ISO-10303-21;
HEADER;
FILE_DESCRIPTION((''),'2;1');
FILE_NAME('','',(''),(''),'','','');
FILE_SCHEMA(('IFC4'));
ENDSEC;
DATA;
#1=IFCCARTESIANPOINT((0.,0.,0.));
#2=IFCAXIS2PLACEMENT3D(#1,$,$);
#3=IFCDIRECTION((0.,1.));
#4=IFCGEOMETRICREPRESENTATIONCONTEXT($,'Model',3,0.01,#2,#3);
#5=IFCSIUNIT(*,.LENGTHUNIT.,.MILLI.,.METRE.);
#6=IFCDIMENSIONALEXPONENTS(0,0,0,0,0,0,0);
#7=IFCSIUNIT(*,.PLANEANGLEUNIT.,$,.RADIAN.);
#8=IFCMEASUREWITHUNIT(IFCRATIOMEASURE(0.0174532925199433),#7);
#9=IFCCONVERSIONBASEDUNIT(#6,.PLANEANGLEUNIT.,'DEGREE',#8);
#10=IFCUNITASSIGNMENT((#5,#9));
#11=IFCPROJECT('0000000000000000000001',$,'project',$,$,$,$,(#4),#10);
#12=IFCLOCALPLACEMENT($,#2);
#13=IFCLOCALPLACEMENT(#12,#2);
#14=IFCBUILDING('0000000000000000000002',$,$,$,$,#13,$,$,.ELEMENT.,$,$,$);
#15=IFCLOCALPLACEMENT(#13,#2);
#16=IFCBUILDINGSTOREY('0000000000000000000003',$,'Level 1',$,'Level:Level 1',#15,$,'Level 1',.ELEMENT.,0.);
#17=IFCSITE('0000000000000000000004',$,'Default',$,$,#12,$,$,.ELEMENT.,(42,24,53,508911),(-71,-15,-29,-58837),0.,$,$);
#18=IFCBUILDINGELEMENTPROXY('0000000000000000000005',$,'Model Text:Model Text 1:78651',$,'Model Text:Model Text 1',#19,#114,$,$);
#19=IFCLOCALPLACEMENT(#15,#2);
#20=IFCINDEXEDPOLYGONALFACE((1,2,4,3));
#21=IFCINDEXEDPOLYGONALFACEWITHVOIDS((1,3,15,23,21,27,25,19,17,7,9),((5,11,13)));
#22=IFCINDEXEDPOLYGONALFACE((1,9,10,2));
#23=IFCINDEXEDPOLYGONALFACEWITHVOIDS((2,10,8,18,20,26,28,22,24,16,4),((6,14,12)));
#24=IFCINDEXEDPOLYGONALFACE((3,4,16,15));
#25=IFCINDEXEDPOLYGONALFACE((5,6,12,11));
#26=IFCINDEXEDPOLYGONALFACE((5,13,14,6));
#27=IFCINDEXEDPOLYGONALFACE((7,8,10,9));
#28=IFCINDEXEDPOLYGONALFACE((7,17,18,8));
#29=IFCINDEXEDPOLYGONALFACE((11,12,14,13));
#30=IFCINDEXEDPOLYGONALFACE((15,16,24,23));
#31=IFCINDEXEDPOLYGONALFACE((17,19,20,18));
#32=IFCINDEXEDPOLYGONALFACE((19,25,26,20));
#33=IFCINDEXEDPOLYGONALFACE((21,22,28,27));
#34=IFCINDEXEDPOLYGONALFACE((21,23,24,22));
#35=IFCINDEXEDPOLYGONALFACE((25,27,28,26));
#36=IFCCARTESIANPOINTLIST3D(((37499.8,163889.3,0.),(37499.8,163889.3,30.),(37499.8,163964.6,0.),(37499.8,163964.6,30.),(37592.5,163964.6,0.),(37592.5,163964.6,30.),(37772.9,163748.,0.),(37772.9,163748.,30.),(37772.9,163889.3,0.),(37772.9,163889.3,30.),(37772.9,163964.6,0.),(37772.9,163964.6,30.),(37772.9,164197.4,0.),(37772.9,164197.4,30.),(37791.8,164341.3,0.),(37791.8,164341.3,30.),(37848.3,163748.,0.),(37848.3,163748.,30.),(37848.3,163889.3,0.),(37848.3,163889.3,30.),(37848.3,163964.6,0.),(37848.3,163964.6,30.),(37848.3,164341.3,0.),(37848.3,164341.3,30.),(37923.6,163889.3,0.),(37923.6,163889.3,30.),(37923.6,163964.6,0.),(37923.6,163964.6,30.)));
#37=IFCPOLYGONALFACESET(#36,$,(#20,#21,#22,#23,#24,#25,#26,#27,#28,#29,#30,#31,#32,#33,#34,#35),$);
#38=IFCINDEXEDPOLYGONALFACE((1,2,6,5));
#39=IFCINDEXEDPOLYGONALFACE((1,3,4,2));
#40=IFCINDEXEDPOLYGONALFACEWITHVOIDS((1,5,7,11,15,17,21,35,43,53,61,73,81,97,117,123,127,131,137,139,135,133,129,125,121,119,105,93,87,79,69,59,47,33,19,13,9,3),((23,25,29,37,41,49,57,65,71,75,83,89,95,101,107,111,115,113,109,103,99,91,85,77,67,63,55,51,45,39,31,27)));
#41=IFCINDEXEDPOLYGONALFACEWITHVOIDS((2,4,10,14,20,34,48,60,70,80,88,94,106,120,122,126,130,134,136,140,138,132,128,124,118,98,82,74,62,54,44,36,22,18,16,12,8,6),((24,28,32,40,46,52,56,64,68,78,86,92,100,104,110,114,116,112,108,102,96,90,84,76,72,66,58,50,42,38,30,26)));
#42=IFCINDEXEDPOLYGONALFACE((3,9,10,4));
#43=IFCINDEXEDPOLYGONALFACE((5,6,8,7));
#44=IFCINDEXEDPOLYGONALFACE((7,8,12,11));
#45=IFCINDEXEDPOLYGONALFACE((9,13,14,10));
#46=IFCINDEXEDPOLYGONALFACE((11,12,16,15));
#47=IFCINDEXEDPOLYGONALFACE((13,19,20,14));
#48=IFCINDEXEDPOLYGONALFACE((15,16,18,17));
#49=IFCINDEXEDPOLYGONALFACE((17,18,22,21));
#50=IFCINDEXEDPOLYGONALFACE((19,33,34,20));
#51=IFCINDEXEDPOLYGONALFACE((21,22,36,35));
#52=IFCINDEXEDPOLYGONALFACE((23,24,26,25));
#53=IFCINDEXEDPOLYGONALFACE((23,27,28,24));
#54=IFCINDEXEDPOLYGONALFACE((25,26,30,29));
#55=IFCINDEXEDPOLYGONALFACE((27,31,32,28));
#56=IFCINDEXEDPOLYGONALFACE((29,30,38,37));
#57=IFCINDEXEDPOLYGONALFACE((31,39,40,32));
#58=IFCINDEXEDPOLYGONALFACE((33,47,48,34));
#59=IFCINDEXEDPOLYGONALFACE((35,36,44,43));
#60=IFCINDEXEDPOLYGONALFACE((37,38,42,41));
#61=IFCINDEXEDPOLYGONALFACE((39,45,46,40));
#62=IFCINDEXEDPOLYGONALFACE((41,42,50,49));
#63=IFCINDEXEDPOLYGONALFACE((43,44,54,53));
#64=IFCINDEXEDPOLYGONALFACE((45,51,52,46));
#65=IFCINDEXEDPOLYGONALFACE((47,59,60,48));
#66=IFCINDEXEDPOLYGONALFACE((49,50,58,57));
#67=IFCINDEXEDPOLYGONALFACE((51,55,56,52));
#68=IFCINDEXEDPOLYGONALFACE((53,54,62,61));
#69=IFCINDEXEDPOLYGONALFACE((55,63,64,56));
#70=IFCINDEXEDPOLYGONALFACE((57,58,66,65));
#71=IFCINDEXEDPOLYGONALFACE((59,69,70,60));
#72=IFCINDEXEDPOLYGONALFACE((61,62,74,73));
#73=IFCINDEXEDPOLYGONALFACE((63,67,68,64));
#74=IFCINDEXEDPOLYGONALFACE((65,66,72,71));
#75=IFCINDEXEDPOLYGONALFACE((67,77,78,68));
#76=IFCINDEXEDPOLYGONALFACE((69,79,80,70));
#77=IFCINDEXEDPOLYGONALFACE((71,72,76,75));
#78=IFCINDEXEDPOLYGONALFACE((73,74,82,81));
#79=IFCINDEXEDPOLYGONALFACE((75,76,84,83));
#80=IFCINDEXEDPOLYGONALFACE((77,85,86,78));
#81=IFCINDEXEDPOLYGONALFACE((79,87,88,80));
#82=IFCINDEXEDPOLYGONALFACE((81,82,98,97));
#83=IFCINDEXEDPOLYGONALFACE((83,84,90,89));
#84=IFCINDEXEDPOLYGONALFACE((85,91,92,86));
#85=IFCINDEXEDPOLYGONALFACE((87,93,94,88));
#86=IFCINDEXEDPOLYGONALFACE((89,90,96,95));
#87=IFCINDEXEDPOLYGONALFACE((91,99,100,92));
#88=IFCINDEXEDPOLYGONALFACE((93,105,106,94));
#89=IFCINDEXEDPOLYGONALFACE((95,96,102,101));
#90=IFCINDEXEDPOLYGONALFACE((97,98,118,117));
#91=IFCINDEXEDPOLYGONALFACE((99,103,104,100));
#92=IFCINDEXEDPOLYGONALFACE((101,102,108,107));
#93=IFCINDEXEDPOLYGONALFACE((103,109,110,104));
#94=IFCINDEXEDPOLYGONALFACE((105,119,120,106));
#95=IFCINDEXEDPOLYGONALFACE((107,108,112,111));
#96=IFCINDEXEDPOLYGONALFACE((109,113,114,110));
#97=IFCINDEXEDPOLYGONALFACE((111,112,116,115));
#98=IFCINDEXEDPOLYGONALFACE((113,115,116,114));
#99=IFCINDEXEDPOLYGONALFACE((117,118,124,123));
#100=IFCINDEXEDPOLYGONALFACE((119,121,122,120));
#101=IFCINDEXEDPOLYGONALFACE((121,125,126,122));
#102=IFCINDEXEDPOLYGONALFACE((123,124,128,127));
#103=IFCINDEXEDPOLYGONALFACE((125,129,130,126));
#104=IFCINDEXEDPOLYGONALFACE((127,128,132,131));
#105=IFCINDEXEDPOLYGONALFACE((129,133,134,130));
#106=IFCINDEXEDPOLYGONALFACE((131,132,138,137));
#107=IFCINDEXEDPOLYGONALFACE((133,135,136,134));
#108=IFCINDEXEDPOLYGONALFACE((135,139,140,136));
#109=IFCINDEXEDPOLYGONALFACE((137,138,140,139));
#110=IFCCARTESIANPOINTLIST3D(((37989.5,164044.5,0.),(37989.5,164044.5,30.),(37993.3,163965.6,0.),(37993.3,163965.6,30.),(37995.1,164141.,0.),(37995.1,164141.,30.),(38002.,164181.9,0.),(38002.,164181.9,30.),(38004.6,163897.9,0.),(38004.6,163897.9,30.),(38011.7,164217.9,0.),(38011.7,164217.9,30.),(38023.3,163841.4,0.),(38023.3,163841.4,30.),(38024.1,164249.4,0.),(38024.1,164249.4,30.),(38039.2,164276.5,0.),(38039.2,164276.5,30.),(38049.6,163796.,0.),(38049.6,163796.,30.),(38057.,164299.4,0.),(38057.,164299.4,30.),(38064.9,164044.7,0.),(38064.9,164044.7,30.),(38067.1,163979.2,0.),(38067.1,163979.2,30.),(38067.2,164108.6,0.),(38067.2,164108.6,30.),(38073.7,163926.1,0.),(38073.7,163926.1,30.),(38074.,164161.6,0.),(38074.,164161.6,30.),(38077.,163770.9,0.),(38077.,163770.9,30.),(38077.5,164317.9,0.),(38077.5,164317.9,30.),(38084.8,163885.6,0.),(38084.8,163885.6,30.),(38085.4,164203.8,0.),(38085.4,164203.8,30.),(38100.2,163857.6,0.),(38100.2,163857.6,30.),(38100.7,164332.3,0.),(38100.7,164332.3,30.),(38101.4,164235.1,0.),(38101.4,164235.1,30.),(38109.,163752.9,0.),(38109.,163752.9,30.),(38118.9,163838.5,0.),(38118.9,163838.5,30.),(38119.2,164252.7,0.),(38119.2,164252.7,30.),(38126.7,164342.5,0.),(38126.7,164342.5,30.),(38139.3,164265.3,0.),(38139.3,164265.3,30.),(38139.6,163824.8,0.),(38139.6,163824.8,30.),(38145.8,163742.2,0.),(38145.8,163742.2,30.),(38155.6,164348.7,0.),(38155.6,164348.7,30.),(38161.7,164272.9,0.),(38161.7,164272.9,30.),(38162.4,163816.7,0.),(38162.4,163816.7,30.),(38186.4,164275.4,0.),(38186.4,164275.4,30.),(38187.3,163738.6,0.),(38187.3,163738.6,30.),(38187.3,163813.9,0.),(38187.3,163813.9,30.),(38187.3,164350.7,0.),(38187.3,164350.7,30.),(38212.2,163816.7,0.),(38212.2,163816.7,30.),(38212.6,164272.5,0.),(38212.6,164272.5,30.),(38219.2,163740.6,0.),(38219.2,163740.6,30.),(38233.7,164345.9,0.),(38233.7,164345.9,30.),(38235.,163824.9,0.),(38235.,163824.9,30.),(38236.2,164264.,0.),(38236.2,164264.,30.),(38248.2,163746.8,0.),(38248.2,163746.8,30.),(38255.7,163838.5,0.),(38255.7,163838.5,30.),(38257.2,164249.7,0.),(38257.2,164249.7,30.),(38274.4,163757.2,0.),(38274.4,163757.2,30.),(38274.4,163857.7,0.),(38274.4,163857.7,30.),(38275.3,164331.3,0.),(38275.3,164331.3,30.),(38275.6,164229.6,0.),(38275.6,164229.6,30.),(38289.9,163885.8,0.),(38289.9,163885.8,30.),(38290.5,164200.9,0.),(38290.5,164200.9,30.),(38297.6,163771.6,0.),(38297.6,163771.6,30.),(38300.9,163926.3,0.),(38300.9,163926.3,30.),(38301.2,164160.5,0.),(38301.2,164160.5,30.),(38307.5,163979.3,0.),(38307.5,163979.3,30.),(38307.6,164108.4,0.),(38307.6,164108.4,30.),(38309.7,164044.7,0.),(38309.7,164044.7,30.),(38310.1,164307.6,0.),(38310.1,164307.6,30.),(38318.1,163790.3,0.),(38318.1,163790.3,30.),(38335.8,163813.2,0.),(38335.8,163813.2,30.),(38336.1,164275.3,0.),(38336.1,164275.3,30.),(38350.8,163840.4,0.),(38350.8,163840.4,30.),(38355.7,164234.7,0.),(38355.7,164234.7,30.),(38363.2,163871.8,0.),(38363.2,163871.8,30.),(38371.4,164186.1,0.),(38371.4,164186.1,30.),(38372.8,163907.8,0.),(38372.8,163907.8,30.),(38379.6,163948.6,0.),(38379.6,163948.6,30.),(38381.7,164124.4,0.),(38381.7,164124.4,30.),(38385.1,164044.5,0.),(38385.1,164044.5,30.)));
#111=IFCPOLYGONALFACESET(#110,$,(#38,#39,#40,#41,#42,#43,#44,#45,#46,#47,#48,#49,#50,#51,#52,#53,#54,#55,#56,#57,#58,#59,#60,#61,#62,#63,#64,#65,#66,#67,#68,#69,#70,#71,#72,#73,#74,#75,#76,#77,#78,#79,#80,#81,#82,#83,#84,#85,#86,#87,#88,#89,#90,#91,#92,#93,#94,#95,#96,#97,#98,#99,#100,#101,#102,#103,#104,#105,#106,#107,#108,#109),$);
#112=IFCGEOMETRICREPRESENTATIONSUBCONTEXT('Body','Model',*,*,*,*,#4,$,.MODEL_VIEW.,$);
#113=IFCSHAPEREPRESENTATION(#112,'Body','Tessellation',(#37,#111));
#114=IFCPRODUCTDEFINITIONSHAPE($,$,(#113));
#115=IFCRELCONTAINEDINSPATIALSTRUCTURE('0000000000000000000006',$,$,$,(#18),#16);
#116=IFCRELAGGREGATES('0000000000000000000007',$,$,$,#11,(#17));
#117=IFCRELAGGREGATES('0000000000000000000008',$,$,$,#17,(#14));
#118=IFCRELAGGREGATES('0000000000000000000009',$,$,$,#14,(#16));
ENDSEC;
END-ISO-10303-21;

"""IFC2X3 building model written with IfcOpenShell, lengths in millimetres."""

from ifc_helpers import new_model, entity, si_unit, converted_unit, direction, frame, origin, place, context, subcontext, project, spatial, polyline, outline, extrude, element, save


model = new_model("IFC2X3")

# Units and contexts
model_context = context("Model", 3, precision=0.01, world=origin(), true_north=direction((0.0, 1.0)))
body_context = subcontext(model_context, "Body", "Model", "MODEL_VIEW")
ifc_project = project(units=[si_unit("LENGTHUNIT", "METRE", prefix="MILLI"), converted_unit("PLANEANGLEUNIT", "DEGREE", entity("IfcRatioMeasure", 0.0174532925199433), si_unit("PLANEANGLEUNIT", "RADIAN"), dimensions=[0, 0, 0, 0, 0, 0, 0])], contexts=[model_context])

# Site, building, storey
site_placement = place(None, origin())
site = spatial("IfcSite", under=ifc_project, at=site_placement, Name="Default", CompositionType="ELEMENT", RefLatitude=(42, 24, 53, 508911), RefLongitude=(-71, -15, -29, -58837), RefElevation=0.0)
building_placement = place(site_placement, origin())
building = spatial("IfcBuilding", under=site, at=building_placement, CompositionType="ELEMENT")
storey_placement = place(building_placement, origin())
storey = spatial("IfcBuildingStorey", under=building, at=storey_placement, Name="Level 1", ObjectType="Level:Level 1", LongName="Level 1", CompositionType="ELEMENT", Elevation=0.0)

# Building element proxy
proxy_1_placement = place(storey_placement, origin())
element("IfcBuildingElementProxy", 1, at=proxy_1_placement, inside=storey, Name="Model Text:Model Text 1:78651", ObjectType="Model Text:Model Text 1", context=body_context, shape_type="SweptSolid", body=[
    extrude(outline(polyline([(-6.8, -218.3), (68.5, -218.3), (68.5, -77.1), (143.8, -77.1), (143.8, -1.7), (68.5, -1.7), (68.5, 375.0), (12.0, 375.0), (-280.0, -1.7), (-280.0, -77.1), (-6.8, -77.1), (-6.8, -218.3)]), holes=[polyline([(-6.8, -1.7), (-187.3, -1.7), (-6.8, 231.1), (-6.8, -1.7)])]), frame((37779.8, 163966.3, 0.0)), (0.0, 0.0, 1.0), 30.0),
    extrude(outline(polyline([(-10.6, -198.7), (68.3, -198.7), (136.5, -190.7), (193.9, -174.7), (240.5, -150.6), (266.9, -124.4), (286.3, -93.2), (298.8, -57.0), (304.3, -15.7), (303.8, 16.2), (299.0, 45.5), (289.9, 72.1), (276.6, 96.0), (258.9, 117.3), (236.9, 136.2), (210.4, 152.5), (179.6, 166.3), (144.1, 177.6), (103.7, 186.3), (8.2, 196.4), (-71.8, 196.7), (-134.0, 189.4), (-183.3, 176.1), (-224.7, 158.4), (-258.2, 133.9), (-283.5, 100.3), (-300.1, 59.5), (-307.1, 13.4), (-306.6, -18.4), (-301.8, -47.5), (-292.8, -74.0), (-279.6, -97.9), (-262.0, -119.2), (-240.0, -138.1), (-213.6, -154.5), (-182.8, -168.4), (-147.3, -179.8), (-106.7, -188.6), (-10.6, -198.7)]), holes=[polyline([(-7.2, -123.5), (-71.0, -118.2), (-123.6, -108.8), (-165.2, -95.4), (-195.7, -78.0), (-212.4, -59.4), (-224.1, -38.7), (-230.6, -15.9), (-231.9, 8.9), (-227.8, 35.0), (-218.1, 58.1), (-202.8, 78.4), (-182.0, 95.8), (-152.6, 109.4), (-111.7, 118.1), (-59.4, 122.0), (4.4, 121.1), (69.6, 115.8), (122.2, 106.7), (162.2, 93.7), (189.5, 77.0), (207.7, 57.4), (220.4, 36.0), (227.5, 12.8), (229.1, -12.1), (225.2, -36.8), (215.9, -59.2), (201.3, -79.3), (181.4, -97.1), (152.6, -111.2), (111.6, -120.3), (58.3, -124.4), (-7.2, -123.5)])]), frame((38188.6, 164043.3, 0.0), z_axis=(0.0, 0.0, 1.0), x_axis=(0.047515, -0.998871, 0.0)), (0.0, 0.0, 1.0), 30.0),
])

save(model, "model.ifc")
